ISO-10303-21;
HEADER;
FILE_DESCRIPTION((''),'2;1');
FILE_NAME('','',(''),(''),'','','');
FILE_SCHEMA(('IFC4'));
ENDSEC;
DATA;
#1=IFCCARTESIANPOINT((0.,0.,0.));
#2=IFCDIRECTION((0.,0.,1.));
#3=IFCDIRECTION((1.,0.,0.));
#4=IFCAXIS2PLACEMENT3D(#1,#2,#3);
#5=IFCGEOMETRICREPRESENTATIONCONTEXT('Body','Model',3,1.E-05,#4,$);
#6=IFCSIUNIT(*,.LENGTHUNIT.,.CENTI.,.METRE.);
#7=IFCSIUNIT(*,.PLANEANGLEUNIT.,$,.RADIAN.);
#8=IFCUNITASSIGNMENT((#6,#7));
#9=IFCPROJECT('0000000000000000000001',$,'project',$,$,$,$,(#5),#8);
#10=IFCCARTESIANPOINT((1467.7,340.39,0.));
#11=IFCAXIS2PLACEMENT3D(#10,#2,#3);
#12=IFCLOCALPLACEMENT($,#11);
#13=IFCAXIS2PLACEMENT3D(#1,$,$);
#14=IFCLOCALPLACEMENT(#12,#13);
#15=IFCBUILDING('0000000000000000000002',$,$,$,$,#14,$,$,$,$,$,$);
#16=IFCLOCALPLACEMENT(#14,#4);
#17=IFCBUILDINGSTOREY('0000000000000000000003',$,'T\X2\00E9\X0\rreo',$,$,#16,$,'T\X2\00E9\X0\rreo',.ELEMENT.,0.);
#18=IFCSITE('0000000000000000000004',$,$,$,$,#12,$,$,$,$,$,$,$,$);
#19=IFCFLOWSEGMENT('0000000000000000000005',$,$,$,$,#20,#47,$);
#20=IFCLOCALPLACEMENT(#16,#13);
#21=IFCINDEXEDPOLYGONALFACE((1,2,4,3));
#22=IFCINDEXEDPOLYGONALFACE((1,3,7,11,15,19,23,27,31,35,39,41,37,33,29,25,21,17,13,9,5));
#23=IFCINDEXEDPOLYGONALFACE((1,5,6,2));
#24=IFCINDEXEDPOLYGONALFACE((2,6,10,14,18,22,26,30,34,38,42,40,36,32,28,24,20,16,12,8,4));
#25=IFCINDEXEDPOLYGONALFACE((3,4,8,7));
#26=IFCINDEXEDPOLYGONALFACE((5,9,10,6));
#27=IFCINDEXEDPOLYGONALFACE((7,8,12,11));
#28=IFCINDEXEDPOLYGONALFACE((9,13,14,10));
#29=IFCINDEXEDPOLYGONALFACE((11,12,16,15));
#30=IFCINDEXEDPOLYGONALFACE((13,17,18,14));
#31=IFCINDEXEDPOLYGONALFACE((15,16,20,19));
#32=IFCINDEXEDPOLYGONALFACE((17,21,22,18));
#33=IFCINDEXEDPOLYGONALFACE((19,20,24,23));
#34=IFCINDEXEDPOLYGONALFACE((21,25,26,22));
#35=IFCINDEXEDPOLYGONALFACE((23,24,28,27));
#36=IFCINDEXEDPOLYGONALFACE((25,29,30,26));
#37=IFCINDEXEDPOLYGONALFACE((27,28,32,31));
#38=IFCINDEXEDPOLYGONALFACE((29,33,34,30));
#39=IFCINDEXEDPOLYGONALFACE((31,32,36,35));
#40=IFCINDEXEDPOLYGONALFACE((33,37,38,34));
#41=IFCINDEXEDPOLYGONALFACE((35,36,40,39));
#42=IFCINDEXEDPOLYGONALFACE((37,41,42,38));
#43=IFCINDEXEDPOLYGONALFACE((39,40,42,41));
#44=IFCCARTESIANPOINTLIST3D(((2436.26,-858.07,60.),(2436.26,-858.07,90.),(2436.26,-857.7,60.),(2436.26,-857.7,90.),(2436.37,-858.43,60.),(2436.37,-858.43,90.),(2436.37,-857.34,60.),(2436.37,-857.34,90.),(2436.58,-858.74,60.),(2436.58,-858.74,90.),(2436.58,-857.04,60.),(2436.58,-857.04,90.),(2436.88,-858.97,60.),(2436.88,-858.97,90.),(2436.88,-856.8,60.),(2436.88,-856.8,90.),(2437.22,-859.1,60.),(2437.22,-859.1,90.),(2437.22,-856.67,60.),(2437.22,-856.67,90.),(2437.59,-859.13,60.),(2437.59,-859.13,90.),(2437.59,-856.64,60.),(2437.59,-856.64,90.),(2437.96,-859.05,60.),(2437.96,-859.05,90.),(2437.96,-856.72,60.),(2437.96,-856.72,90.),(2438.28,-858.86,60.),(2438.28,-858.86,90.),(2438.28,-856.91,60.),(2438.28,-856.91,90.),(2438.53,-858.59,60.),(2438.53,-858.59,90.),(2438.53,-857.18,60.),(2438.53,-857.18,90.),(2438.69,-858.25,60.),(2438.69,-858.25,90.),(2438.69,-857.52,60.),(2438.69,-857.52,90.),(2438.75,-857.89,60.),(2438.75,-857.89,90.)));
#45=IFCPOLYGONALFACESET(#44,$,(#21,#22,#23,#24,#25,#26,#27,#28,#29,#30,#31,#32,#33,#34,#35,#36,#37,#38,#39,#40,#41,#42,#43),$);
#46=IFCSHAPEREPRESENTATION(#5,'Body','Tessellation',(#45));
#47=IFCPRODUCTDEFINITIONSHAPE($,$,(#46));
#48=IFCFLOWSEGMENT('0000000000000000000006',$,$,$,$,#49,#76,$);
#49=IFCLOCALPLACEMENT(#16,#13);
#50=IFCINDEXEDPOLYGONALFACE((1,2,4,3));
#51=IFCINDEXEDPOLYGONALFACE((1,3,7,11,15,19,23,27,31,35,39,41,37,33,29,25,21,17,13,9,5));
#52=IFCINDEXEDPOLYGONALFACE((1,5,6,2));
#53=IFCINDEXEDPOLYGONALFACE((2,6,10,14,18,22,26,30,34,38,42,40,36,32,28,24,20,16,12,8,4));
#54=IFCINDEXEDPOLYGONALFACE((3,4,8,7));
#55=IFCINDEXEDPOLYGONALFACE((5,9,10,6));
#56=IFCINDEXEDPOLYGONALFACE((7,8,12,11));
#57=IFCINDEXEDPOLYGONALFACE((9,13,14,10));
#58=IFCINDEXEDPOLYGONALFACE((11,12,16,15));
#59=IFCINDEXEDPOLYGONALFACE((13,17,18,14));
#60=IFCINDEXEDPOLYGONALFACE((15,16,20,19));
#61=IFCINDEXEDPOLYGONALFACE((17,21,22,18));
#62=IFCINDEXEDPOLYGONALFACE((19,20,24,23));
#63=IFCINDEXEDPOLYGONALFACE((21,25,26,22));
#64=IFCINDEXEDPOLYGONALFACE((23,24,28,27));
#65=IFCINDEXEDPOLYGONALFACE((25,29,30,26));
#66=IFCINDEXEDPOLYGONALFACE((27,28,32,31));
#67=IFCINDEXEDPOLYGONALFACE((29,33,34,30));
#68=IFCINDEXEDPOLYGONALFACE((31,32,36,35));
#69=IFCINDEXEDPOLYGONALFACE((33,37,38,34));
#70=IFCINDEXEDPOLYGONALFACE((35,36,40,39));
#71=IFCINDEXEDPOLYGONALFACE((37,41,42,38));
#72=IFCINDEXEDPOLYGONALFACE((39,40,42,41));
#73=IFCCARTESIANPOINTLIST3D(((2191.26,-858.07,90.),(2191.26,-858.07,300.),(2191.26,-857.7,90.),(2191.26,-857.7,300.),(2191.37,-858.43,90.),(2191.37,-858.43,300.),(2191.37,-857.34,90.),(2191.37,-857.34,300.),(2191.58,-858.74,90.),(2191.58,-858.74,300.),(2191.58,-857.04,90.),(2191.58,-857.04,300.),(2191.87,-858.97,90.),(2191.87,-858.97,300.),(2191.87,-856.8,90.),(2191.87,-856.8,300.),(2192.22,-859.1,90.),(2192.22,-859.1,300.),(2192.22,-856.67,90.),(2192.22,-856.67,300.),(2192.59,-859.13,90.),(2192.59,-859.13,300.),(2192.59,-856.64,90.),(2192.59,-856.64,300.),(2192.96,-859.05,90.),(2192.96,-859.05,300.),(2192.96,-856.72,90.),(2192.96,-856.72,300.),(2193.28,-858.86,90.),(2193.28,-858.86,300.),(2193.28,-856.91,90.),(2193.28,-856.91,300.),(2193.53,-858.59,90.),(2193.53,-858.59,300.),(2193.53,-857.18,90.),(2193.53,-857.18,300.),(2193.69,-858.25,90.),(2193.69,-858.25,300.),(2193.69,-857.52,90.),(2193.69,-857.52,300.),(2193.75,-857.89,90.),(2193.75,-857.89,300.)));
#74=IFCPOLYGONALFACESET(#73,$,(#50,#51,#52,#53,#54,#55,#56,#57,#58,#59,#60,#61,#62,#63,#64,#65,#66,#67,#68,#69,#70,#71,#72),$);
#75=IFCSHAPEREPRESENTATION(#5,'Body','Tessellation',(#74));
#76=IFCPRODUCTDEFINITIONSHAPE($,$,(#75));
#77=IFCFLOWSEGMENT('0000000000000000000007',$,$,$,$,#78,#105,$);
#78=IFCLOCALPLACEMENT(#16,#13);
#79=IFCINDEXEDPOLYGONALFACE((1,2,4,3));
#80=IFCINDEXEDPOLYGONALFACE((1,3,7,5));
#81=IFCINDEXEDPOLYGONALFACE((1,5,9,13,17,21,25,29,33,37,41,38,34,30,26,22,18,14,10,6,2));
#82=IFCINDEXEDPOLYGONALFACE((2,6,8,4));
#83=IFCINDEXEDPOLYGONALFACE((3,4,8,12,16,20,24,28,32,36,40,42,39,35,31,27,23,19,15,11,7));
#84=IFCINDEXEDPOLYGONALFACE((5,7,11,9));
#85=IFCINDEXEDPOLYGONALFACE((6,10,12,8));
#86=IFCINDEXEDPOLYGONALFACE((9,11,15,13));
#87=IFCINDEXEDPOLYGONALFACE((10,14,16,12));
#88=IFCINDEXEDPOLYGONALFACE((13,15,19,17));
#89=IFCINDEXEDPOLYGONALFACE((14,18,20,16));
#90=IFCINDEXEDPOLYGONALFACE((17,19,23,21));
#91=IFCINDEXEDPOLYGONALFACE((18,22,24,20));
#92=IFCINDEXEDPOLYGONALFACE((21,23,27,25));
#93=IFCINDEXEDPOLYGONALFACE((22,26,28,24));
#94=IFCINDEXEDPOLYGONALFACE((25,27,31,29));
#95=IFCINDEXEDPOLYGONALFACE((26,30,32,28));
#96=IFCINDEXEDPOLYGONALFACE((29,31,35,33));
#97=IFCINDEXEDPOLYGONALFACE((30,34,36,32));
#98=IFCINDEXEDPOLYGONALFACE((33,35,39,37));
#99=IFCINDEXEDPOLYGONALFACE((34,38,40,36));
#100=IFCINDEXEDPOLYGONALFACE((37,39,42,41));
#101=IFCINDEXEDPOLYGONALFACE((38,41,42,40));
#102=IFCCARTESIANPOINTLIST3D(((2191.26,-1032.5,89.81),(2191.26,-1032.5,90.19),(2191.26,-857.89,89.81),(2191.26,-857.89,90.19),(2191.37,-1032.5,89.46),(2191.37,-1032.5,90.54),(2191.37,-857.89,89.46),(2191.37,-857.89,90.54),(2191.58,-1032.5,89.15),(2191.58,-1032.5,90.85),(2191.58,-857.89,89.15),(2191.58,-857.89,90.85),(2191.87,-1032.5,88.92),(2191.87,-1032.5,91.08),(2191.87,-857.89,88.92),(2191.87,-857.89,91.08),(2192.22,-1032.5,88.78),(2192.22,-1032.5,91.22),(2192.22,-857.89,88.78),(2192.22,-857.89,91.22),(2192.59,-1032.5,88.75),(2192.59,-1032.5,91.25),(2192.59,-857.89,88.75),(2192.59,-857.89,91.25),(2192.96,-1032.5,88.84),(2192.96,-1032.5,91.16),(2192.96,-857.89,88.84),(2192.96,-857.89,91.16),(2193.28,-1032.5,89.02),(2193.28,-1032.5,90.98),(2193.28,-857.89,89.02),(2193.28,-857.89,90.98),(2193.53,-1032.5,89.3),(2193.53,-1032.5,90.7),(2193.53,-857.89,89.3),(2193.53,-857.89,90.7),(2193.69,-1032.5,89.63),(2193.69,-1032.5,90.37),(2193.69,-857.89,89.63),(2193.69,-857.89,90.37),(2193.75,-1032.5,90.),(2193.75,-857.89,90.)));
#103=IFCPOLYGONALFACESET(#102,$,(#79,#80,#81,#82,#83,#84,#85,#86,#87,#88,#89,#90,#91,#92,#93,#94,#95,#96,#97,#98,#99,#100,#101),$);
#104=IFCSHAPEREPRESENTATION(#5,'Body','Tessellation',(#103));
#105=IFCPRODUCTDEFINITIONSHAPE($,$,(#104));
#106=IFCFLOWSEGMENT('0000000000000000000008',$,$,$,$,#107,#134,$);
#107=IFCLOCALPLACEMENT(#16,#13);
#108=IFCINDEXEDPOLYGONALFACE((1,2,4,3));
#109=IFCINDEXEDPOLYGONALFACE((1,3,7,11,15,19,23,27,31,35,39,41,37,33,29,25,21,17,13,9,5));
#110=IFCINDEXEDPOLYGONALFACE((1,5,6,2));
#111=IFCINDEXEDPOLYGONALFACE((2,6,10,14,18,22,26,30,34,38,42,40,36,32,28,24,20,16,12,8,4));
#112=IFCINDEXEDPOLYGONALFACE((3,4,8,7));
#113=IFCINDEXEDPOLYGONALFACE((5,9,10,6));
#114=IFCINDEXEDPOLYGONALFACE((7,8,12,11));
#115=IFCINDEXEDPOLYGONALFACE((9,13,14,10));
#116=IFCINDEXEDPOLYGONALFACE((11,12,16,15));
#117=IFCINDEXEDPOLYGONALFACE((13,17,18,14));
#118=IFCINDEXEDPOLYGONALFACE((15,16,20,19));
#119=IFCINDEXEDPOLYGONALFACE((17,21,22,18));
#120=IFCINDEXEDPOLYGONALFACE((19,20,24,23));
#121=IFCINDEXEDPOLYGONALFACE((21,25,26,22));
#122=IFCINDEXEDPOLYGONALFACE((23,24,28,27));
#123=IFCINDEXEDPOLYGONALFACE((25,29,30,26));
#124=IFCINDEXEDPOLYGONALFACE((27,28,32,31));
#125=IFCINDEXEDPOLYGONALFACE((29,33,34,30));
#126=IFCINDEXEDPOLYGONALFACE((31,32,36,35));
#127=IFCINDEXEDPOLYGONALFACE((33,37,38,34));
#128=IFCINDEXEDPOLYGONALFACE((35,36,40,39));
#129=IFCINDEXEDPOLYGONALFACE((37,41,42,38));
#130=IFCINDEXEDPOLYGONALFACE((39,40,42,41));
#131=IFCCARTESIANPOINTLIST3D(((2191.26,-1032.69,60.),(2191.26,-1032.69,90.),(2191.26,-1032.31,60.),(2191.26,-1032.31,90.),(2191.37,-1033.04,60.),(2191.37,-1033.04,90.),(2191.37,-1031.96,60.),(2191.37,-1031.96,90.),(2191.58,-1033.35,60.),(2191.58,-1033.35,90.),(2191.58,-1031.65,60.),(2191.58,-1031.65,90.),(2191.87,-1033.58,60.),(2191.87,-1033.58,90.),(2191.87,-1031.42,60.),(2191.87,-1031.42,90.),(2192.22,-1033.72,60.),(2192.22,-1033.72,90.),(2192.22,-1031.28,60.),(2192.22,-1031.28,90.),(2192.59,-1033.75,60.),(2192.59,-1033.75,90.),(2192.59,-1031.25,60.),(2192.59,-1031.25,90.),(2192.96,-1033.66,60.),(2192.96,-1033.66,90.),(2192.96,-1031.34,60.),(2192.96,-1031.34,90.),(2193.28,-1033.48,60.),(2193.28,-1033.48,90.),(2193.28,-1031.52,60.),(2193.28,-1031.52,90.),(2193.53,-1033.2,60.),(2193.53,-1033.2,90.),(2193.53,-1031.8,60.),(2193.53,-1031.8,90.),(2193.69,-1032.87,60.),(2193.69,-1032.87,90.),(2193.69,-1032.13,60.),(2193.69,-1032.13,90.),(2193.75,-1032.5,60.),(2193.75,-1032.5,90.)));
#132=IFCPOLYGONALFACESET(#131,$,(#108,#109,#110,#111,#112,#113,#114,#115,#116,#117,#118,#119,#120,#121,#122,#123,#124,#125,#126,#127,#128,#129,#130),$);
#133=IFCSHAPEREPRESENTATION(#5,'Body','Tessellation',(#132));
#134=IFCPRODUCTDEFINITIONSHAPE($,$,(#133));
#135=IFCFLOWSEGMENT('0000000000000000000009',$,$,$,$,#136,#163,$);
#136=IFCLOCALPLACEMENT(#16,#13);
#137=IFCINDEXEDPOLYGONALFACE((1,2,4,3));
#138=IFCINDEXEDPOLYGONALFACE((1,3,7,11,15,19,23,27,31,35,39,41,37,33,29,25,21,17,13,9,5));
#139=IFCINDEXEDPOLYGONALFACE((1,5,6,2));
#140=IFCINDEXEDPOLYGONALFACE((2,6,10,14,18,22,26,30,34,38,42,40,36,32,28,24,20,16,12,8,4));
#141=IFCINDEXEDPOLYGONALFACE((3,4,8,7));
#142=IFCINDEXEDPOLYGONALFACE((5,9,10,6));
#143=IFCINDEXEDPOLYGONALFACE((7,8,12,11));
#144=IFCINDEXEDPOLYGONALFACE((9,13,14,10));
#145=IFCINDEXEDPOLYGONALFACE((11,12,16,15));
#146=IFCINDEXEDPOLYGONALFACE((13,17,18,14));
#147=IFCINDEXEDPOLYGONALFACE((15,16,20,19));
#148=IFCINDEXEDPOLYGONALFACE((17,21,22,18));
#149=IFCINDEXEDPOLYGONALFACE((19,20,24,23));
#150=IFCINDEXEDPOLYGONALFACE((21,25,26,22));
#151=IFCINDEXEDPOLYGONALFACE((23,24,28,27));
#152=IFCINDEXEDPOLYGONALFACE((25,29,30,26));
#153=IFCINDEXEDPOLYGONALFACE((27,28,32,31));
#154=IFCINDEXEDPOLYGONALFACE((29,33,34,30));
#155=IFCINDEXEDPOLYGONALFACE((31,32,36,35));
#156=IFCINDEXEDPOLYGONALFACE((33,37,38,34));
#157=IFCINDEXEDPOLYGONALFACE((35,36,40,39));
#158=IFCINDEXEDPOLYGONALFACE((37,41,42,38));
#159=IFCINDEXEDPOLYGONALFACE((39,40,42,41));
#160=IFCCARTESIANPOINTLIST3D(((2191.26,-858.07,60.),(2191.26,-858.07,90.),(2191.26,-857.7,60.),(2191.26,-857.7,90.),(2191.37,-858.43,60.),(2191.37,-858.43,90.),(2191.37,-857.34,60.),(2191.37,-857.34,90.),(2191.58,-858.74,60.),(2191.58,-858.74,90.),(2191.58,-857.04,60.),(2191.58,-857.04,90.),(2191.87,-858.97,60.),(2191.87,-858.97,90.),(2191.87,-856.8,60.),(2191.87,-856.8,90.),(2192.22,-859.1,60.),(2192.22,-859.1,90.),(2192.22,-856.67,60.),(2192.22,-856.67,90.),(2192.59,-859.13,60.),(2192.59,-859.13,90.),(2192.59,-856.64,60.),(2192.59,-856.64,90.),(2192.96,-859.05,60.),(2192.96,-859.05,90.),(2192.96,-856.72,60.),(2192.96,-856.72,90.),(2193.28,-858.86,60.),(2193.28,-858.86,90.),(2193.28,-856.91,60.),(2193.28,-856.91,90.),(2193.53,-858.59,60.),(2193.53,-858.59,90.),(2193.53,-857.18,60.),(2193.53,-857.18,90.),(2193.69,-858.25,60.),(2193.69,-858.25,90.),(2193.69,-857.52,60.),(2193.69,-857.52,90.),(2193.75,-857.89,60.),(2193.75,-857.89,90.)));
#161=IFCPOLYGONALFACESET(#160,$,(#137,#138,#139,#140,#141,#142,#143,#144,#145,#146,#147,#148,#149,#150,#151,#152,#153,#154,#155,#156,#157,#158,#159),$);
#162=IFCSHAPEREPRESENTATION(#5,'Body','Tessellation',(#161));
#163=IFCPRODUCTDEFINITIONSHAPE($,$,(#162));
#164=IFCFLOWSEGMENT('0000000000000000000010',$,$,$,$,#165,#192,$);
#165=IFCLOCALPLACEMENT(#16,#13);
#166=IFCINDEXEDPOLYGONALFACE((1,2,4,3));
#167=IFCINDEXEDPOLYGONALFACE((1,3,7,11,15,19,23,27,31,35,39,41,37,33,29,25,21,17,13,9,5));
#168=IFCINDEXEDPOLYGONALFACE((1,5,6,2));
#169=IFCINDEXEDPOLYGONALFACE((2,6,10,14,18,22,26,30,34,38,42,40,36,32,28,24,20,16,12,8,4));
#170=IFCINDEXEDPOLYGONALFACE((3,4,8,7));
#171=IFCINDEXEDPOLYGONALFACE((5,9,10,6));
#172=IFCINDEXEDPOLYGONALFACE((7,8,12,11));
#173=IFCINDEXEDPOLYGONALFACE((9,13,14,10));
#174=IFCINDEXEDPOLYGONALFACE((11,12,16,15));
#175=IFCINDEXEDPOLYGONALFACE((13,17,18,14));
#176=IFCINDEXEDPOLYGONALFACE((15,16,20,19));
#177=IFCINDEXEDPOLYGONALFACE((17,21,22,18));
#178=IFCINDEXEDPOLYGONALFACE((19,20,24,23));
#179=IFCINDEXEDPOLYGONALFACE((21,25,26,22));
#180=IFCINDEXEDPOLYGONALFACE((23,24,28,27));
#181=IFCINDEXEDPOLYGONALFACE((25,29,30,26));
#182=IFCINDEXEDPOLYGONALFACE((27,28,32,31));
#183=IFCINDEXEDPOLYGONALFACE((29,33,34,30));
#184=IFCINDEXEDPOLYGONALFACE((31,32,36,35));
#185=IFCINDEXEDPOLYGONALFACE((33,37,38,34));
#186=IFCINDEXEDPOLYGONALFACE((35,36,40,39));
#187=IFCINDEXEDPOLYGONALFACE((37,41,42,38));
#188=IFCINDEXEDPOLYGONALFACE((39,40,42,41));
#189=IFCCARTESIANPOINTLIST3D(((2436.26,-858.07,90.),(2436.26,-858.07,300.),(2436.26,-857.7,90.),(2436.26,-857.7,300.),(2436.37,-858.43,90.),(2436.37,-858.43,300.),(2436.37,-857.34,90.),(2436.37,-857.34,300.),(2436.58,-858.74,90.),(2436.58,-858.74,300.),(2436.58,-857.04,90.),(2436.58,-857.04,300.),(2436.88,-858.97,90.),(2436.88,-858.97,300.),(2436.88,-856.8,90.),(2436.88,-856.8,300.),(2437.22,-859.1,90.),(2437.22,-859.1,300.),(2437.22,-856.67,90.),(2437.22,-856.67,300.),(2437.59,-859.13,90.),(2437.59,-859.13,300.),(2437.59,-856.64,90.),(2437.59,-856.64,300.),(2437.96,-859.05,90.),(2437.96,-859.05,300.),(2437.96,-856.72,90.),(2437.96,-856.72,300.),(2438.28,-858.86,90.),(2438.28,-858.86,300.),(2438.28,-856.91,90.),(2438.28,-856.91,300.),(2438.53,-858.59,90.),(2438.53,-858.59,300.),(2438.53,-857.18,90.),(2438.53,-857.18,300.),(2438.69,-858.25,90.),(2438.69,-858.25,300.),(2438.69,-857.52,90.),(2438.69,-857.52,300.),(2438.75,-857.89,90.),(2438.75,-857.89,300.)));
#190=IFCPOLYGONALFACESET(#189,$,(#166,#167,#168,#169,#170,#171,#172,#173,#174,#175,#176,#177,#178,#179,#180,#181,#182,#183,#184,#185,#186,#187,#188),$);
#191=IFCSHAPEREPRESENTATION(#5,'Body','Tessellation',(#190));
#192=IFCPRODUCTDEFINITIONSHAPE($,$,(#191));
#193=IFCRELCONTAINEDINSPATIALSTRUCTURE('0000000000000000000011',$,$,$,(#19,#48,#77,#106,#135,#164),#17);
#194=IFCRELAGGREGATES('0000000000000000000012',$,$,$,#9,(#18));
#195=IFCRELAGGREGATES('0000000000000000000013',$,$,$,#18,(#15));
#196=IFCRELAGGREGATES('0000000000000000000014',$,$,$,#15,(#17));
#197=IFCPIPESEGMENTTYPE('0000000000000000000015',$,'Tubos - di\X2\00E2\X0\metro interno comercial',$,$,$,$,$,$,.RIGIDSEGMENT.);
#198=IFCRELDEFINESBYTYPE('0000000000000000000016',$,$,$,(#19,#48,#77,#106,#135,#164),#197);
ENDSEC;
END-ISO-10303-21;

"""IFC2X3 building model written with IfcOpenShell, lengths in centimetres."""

from ifc_helpers import new_model, si_unit, frame, origin, origin_with_axes, origin_2d_with_axis, place, context, project, spatial, circle, extrude, type_object, element, save


model = new_model("IFC2X3")

# Units and contexts
model_context = context("Model", 3, precision=1e-05, world=origin_with_axes(), identifier="Body")
ifc_project = project(units=[si_unit("LENGTHUNIT", "METRE", prefix="CENTI"), si_unit("PLANEANGLEUNIT", "RADIAN")], contexts=[model_context])

# Site, building, storey
site_placement = place(None, frame((1467.7, 340.39, 0.0), z_axis=(0.0, 0.0, 1.0), x_axis=(1.0, 0.0, 0.0)))
site = spatial("IfcSite", under=ifc_project, at=site_placement)
building_placement = place(site_placement, origin())
building = spatial("IfcBuilding", under=site, at=building_placement)
storey_placement = place(building_placement, origin_with_axes())
storey = spatial("IfcBuildingStorey", under=building, at=storey_placement, Name="Térreo", LongName="Térreo", CompositionType="ELEMENT", Elevation=0.0)

# Flow segments
pipe_segment_type = type_object("IfcPipeSegmentType", Name="Tubos - diâmetro interno comercial", PredefinedType="RIGIDSEGMENT")
flow_segment_1_placement = place(storey_placement, frame((2437.5, -857.89, 90.0), z_axis=(0.0, 0.0, 1.0), x_axis=(1.0, 0.0, 0.0)))
element("IfcFlowSegment", 1, at=flow_segment_1_placement, inside=storey, type_object=pipe_segment_type, context=model_context, shape_type="SolidModel", body=[
    extrude(circle(Radius=1.25, at=origin_2d_with_axis()), frame((0.0, 0.0, 0.0), z_axis=(0.0, 0.0, -1.0), x_axis=(1.0, 0.0, 0.0)), (0.0, 0.0, 1.0), 30.0),
])
flow_segment_2_placement = place(storey_placement, frame((2192.5, -857.89, 300.0), z_axis=(0.0, 0.0, 1.0), x_axis=(1.0, 0.0, 0.0)))
element("IfcFlowSegment", 2, at=flow_segment_2_placement, inside=storey, type_object=pipe_segment_type, context=model_context, shape_type="SolidModel", body=[
    extrude(circle(Radius=1.25, at=origin_2d_with_axis()), frame((0.0, 0.0, 0.0), z_axis=(0.0, 0.0, -1.0), x_axis=(1.0, 0.0, 0.0)), (0.0, 0.0, 1.0), 210.0),
])
flow_segment_3_placement = place(storey_placement, frame((2192.5, -945.19, 91.25), z_axis=(0.0, 0.0, 1.0), x_axis=(1.0, 0.0, 0.0)))
element("IfcFlowSegment", 3, at=flow_segment_3_placement, inside=storey, type_object=pipe_segment_type, context=model_context, shape_type="SolidModel", body=[
    extrude(circle(Radius=1.25, at=origin_2d_with_axis()), frame((0.0, 87.31, -1.25), z_axis=(0.0, -1.0, 0.0), x_axis=(1.0, 0.0, 0.0)), (0.0, 0.0, 1.0), 174.61),
])
for number, where, z_axis, x_axis in (
    (4, (2192.5, -1032.5, 90.0), (0.0, 0.0, 1.0), (1.0, 0.0, 0.0)),
    (5, (2192.5, -857.89, 90.0), (0.0, 0.0, 1.0), (1.0, 0.0, 0.0)),
):
    element("IfcFlowSegment", number, at=place(storey_placement, frame(where, z_axis=z_axis, x_axis=x_axis)), inside=storey, type_object=pipe_segment_type, context=model_context, shape_type="SolidModel", body=[
        extrude(circle(Radius=1.25, at=origin_2d_with_axis()), frame((0.0, 0.0, 0.0), z_axis=(0.0, 0.0, -1.0), x_axis=(1.0, 0.0, 0.0)), (0.0, 0.0, 1.0), 30.0),
    ])
for number, where, z_axis, x_axis in (
    (6, (2437.5, -857.89, 300.0), (0.0, 0.0, 1.0), (1.0, 0.0, 0.0)),
):
    element("IfcFlowSegment", number, at=place(storey_placement, frame(where, z_axis=z_axis, x_axis=x_axis)), inside=storey, type_object=pipe_segment_type, context=model_context, shape_type="SolidModel", body=[
        extrude(circle(Radius=1.25, at=origin_2d_with_axis()), frame((0.0, 0.0, 0.0), z_axis=(0.0, 0.0, -1.0), x_axis=(1.0, 0.0, 0.0)), (0.0, 0.0, 1.0), 210.0),
    ])

save(model, "model.ifc")
